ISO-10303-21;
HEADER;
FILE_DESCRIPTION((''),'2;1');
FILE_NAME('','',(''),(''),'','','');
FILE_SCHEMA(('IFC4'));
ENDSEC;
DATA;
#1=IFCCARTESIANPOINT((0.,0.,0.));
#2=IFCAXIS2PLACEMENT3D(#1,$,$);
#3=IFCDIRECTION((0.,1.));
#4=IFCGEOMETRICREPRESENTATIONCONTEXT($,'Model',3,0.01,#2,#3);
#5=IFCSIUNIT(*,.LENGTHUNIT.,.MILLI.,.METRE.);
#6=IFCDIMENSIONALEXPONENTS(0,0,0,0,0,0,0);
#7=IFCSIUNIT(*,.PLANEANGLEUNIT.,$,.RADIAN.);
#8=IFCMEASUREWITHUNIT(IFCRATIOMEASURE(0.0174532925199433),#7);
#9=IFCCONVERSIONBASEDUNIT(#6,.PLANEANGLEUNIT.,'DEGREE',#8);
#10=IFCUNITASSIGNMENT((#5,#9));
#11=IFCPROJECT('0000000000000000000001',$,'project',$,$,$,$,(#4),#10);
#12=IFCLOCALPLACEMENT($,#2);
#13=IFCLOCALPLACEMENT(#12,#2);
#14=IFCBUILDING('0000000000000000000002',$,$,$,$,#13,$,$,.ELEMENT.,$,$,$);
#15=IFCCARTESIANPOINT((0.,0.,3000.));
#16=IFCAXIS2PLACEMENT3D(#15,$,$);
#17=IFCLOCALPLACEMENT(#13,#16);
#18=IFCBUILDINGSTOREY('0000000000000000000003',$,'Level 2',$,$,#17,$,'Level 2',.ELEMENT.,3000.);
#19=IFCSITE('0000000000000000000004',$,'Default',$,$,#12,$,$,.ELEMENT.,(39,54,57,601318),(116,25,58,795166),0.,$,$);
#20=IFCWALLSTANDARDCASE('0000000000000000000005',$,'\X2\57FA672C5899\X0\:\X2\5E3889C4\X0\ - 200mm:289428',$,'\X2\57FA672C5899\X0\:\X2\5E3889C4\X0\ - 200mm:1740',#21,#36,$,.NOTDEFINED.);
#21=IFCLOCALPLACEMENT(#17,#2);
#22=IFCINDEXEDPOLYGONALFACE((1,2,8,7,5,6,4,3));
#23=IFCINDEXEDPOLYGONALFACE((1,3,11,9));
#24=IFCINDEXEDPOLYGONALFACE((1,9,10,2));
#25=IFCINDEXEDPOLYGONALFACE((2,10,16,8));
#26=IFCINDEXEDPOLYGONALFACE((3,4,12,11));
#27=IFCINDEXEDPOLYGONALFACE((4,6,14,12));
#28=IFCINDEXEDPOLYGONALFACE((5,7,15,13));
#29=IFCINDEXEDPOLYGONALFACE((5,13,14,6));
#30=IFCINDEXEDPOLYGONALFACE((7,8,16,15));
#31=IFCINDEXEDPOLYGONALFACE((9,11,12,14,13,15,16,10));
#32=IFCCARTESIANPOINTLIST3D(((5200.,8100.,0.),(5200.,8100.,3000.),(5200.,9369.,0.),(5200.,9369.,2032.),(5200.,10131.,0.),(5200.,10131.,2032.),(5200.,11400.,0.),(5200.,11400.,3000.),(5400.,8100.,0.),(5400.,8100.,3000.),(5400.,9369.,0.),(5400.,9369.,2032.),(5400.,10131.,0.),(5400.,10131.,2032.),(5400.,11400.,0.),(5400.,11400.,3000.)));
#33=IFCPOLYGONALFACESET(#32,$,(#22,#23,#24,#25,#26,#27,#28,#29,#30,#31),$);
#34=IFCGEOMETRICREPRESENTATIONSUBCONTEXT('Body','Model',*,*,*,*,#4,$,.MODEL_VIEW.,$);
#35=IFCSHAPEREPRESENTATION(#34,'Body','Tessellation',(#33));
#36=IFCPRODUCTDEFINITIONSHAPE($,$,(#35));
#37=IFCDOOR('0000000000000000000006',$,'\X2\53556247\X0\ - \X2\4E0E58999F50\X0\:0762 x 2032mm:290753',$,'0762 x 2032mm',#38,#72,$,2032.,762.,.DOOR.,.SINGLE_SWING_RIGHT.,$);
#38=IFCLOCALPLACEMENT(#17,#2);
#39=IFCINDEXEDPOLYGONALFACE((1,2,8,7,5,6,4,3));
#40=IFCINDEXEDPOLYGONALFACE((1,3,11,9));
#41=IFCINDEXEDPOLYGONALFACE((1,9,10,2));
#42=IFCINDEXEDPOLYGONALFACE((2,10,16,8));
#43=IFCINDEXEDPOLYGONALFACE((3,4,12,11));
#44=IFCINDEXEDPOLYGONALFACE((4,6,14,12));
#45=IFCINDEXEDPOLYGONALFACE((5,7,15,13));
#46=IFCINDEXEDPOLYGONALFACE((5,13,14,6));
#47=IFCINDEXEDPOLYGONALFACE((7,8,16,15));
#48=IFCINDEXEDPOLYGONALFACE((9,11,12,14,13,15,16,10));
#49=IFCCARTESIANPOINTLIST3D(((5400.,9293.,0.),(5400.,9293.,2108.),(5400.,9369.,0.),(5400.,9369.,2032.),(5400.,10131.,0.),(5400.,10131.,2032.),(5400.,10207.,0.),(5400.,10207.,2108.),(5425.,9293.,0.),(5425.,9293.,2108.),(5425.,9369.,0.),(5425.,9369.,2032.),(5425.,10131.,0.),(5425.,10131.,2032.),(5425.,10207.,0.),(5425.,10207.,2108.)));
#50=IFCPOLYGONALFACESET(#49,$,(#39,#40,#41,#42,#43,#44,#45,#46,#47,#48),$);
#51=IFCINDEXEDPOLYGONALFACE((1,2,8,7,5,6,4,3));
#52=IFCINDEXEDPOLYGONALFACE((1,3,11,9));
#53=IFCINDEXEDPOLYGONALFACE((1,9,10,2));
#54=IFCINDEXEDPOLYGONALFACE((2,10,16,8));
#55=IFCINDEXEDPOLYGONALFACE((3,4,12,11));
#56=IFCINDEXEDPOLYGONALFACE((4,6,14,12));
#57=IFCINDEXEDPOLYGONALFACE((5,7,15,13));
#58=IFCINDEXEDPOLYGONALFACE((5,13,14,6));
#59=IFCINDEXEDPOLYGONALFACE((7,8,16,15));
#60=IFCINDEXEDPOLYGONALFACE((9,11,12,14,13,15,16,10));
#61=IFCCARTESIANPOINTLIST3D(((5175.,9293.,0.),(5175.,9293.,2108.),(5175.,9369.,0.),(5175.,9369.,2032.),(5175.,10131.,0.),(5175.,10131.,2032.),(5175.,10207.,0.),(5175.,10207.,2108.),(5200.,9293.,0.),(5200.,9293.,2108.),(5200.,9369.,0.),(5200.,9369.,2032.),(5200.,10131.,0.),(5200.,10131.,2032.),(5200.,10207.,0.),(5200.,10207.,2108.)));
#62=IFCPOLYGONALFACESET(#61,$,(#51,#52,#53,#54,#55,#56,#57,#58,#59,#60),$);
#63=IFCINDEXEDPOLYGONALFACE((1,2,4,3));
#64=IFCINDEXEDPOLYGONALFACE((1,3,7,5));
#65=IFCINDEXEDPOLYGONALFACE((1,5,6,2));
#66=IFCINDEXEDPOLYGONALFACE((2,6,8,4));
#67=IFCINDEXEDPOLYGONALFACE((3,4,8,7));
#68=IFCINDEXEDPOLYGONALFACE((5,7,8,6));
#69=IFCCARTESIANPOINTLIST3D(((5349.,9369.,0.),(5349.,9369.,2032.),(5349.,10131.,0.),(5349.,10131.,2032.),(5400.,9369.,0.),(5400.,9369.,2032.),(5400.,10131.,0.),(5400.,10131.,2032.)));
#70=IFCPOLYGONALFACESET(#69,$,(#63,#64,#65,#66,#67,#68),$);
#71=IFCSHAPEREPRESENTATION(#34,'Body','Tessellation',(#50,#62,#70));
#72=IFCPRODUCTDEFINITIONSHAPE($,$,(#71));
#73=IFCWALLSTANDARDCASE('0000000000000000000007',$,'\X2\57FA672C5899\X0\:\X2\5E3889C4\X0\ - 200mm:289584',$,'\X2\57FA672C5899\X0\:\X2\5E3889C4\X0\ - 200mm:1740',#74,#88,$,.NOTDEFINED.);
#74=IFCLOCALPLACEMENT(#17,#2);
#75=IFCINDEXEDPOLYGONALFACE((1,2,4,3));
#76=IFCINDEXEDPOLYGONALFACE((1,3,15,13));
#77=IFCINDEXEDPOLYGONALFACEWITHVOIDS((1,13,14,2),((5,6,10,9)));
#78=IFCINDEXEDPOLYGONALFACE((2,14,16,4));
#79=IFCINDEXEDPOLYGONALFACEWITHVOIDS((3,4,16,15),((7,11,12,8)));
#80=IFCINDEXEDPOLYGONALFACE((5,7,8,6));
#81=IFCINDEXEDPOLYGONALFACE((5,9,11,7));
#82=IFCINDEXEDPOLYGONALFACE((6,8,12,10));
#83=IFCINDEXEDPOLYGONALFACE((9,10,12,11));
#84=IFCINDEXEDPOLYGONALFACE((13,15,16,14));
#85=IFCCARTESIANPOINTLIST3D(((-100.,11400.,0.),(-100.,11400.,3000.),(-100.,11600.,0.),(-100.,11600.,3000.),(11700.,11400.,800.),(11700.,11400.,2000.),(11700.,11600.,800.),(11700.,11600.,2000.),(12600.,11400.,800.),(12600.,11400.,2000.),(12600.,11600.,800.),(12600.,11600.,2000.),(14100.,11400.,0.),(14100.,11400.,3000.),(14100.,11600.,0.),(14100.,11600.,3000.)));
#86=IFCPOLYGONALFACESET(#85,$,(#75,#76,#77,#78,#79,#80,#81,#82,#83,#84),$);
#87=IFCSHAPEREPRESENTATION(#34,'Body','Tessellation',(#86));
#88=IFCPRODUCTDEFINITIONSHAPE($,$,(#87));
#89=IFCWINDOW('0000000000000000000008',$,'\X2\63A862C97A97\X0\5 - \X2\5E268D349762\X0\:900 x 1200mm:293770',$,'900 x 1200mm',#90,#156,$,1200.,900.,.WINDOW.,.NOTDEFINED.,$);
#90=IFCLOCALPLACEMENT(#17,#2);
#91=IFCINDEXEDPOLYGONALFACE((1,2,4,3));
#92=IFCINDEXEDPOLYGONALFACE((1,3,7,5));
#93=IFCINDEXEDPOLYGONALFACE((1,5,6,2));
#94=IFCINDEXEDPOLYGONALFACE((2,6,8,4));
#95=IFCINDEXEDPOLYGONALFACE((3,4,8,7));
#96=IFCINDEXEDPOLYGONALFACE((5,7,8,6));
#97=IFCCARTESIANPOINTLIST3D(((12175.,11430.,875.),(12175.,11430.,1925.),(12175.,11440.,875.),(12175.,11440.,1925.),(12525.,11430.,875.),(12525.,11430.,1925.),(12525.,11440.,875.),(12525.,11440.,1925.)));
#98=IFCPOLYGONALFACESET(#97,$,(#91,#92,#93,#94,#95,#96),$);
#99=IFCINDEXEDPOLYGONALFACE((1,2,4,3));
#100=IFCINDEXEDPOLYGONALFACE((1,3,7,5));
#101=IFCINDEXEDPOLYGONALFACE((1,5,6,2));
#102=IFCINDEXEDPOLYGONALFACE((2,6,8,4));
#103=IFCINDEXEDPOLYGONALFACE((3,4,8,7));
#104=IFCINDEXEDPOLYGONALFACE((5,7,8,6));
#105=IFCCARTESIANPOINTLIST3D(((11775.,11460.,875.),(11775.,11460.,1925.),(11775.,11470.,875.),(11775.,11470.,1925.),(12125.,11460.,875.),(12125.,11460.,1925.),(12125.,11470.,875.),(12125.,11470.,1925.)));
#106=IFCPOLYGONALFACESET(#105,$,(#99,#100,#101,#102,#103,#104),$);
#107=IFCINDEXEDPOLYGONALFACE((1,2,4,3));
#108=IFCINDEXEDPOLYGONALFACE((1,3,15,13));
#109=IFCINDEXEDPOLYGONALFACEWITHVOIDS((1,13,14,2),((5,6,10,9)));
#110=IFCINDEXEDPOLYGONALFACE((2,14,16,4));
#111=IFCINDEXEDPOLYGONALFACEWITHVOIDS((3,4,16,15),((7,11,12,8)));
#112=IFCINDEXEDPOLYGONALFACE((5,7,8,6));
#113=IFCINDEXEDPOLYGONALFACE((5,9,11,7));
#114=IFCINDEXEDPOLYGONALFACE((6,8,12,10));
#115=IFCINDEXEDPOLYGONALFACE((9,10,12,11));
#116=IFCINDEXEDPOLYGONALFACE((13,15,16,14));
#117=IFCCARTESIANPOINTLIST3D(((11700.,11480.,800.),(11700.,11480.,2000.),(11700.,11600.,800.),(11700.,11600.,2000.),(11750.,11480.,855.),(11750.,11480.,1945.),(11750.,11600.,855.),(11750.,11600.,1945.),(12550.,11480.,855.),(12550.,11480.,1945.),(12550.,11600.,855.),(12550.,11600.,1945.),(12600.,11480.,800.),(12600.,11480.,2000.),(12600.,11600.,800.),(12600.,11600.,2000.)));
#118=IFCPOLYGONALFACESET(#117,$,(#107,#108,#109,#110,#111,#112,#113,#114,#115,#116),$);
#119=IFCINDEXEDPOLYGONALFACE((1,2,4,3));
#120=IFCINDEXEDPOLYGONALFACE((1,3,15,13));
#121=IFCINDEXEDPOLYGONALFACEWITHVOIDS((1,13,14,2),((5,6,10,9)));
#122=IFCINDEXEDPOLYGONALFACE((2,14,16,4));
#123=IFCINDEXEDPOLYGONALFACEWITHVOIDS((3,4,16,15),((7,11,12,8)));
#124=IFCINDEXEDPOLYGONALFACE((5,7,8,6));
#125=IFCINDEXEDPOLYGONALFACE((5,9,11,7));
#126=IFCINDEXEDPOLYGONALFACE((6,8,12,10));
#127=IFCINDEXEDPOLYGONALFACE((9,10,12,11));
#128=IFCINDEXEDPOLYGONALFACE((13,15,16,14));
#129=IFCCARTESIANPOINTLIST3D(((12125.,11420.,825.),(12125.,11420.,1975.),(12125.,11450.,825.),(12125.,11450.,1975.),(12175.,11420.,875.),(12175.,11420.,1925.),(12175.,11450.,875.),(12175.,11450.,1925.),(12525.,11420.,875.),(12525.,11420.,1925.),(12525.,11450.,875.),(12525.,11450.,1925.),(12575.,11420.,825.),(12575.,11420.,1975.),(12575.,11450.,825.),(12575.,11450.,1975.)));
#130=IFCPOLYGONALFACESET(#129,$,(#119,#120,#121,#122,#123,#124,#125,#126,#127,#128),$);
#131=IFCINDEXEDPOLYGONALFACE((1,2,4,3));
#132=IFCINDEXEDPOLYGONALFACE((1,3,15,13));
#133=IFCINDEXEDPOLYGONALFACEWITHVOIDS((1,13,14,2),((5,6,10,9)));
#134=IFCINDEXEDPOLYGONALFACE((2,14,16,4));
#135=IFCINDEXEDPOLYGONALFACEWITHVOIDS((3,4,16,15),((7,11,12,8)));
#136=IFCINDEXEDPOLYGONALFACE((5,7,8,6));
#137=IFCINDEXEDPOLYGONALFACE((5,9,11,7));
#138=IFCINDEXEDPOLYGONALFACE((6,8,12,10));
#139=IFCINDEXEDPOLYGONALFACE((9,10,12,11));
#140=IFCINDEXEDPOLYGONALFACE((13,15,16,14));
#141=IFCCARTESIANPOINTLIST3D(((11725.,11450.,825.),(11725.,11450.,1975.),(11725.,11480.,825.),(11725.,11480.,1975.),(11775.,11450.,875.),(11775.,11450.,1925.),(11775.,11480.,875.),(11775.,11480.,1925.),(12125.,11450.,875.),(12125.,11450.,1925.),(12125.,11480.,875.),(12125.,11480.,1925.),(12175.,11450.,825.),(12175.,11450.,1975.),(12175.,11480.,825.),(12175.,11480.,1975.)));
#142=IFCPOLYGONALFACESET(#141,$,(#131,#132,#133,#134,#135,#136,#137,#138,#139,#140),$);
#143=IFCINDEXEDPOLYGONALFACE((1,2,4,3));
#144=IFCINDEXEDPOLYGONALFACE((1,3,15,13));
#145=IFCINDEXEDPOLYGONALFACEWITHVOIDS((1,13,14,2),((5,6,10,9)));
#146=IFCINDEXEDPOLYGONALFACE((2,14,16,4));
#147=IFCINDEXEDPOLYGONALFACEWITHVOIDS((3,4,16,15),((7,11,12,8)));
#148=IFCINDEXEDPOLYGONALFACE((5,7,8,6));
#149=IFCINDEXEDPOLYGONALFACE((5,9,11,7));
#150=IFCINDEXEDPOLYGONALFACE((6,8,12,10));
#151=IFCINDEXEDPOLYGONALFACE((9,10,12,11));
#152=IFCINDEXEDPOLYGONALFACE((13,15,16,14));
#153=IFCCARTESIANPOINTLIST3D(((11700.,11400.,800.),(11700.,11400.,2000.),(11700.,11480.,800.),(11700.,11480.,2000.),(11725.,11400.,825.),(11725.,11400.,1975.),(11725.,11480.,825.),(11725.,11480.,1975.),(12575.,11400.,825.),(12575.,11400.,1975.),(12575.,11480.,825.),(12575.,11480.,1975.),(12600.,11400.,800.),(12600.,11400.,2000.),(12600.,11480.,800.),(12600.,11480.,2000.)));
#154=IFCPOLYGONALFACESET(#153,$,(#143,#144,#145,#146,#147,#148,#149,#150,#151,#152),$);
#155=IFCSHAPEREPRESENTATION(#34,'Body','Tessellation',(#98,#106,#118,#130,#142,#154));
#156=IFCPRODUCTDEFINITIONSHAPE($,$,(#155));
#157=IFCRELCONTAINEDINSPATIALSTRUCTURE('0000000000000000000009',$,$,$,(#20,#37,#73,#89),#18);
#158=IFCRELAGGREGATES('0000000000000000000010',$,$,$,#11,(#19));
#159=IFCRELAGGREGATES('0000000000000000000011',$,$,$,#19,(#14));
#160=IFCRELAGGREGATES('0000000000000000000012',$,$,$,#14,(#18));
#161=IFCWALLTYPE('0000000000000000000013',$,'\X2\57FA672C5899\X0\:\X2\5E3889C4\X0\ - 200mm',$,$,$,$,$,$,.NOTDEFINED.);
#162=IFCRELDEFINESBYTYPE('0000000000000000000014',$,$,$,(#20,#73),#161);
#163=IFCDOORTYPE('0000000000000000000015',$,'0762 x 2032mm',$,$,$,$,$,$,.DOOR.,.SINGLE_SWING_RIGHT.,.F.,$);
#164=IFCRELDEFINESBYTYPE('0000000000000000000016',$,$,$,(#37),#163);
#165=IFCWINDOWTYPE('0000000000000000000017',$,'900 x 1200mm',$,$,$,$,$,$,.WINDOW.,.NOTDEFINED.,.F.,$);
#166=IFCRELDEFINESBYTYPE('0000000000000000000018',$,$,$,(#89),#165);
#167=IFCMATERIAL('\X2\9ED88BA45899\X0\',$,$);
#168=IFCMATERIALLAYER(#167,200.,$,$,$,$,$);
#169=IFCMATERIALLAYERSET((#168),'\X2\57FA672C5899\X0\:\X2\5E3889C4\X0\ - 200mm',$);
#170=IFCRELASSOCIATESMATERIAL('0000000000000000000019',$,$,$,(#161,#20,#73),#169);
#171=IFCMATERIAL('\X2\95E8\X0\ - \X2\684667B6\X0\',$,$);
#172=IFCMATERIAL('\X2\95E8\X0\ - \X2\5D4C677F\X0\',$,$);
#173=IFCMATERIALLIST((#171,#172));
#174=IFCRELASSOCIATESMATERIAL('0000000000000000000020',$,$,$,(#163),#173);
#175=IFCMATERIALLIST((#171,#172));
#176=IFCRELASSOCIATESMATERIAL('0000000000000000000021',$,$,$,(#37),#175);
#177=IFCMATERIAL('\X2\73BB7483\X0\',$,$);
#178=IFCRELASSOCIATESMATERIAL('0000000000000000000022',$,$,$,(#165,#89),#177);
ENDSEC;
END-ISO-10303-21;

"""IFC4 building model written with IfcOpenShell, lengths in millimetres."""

from ifc_helpers import new_model, entity, si_unit, converted_unit, direction, frame, frame_2d, origin, origin_2d_with_axis, place, context, subcontext, project, spatial, polyline, rectangle, outline, extrude, source, transform, mapped, material, material_list, layer, layer_set, layer_usage, type_object, type_shapes, element, fill, save


model = new_model("IFC4")

# Units and contexts
model_context = context("Model", 3, precision=0.01, world=origin(), true_north=direction((0.0, 1.0)))
body_context = subcontext(model_context, "Body", "Model", "MODEL_VIEW")
ifc_project = project(units=[si_unit("LENGTHUNIT", "METRE", prefix="MILLI"), converted_unit("PLANEANGLEUNIT", "DEGREE", entity("IfcRatioMeasure", 0.0174532925199433), si_unit("PLANEANGLEUNIT", "RADIAN"), dimensions=[0, 0, 0, 0, 0, 0, 0])], contexts=[model_context])

# Site, building, storey
site_placement = place(None, origin())
site = spatial("IfcSite", under=ifc_project, at=site_placement, Name="Default", CompositionType="ELEMENT", RefLatitude=(39, 54, 57, 601318), RefLongitude=(116, 25, 58, 795166), RefElevation=0.0)
building_placement = place(site_placement, origin())
building = spatial("IfcBuilding", under=site, at=building_placement, CompositionType="ELEMENT")
storey_placement = place(building_placement, frame((0.0, 0.0, 3000.0)))
storey = spatial("IfcBuildingStorey", under=building, at=storey_placement, Name="Level 2", LongName="Level 2", CompositionType="ELEMENT", Elevation=3000.0)

# Shared definitions
ifc_material_1 = material(Name="默认墙")
ifc_layer_1 = layer(ifc_material_1, 200.0)
ifc_layer_set_1 = layer_set([ifc_layer_1], Name="基本墙:常规 - 200mm")
wall_type = type_object("IfcWallType", Name="基本墙:常规 - 200mm", PredefinedType="NOTDEFINED", material=ifc_layer_set_1)

# Wall, opening, door
ifc_layer_usage_1 = layer_usage(ifc_layer_set_1, "AXIS2", "NEGATIVE", 100.0)
wall_1_placement = place(storey_placement, frame((5300.0, 8100.0, 0.0), z_axis=(0.0, 0.0, 1.0), x_axis=(0.0, 1.0, 0.0)))
wall_1 = element("IfcWallStandardCase", 1, at=wall_1_placement, inside=storey, type_object=wall_type, material=ifc_layer_usage_1, Name="基本墙:常规 - 200mm:289428", ObjectType="基本墙:常规 - 200mm:1740", PredefinedType="NOTDEFINED", context=body_context, shape_type="SweptSolid", body=[
    extrude(rectangle(XDim=3300.0, YDim=200.0, at=frame_2d((1650.0, 0.0), x_axis=(-1.0, 0.0))), origin(), (0.0, 0.0, 1.0), 3000.0),
])
opening_1_placement = place(wall_1_placement, frame((2031.0, 100.0, 0.0)))
opening_1 = element("IfcOpeningElement", 2, at=opening_1_placement, cuts=wall_1, ObjectType="Opening", PredefinedType="OPENING", context=body_context, shape_type="SweptSolid", body=[
    extrude(rectangle(XDim=762.0, YDim=2032.0, at=frame_2d((1016.0, 381.0), x_axis=(0.0, 1.0))), frame((0.0, 0.0, 0.0), z_axis=(0.0, -1.0, 0.0), x_axis=(0.0, 0.0, 1.0)), (0.0, 0.0, 1.0), 200.0),
])
ifc_material_2 = material(Name="门 - 框架")
ifc_material_3 = material(Name="门 - 嵌板")
ifc_material_list_1 = material_list([ifc_material_2, ifc_material_3])
ifc_material_list_2 = material_list([ifc_material_2, ifc_material_3])
door_type = type_object("IfcDoorType", Name="0762 x 2032mm", OperationType="SINGLE_SWING_RIGHT", ParameterTakesPrecedence=False, PredefinedType="DOOR", material=ifc_material_list_2)
shared_shape_1 = source(origin(), body_context, "Body", "SweptSolid", [
    extrude(outline(polyline([(-457.0, -1073.0), (457.0, -1073.0), (457.0, 1035.0), (381.0, 1035.0), (381.0, -997.0), (-381.0, -997.0), (-381.0, 1035.0), (-457.0, 1035.0), (-457.0, -1073.0)])), frame((381.0, 200.0, 1035.0), z_axis=(0.0, 1.0, 0.0), x_axis=(1.0, 0.0, 0.0)), (0.0, 0.0, 1.0), 25.0),
    extrude(outline(polyline([(-1073.0, -457.0), (1035.0, -457.0), (1035.0, -381.0), (-997.0, -381.0), (-997.0, 381.0), (1035.0, 381.0), (1035.0, 457.0), (-1073.0, 457.0), (-1073.0, -457.0)])), frame((381.0, -25.0, 1035.0), z_axis=(0.0, 1.0, 0.0), x_axis=(0.0, 0.0, -1.0)), (0.0, 0.0, 1.0), 25.0),
    extrude(rectangle(XDim=51.0, YDim=762.0, at=frame_2d((0.0, 0.0), x_axis=(1.0, 0.0))), frame((381.0, 174.5, 0.0), z_axis=(0.0, 0.0, 1.0), x_axis=(0.0, 1.0, 0.0)), (0.0, 0.0, 1.0), 2032.0),
])
type_shapes(door_type, [shared_shape_1])
door_placement = place(opening_1_placement, frame((0.0, 0.0, 0.0), z_axis=(0.0, 0.0, 1.0), x_axis=(-1.0, 0.0, 0.0)))
door = element("IfcDoor", 3, at=door_placement, inside=storey, type_object=door_type, material=ifc_material_list_1, Name="单扇 - 与墙齐:0762 x 2032mm:290753", ObjectType="0762 x 2032mm", OperationType="SINGLE_SWING_RIGHT", OverallHeight=2032.0, OverallWidth=762.0, PredefinedType="DOOR", context=body_context, shape_type="MappedRepresentation", body=[
    mapped(shared_shape_1, transform((0.0, 0.0, 0.0), scale=1.0)),
])
fill(opening_1, door)

# Wall, opening, window
ifc_layer_usage_2 = layer_usage(ifc_layer_set_1, "AXIS2", "NEGATIVE", 100.0)
wall_2_placement = place(storey_placement, frame((-100.0, 11500.0, 0.0)))
wall_2 = element("IfcWallStandardCase", 4, at=wall_2_placement, inside=storey, type_object=wall_type, material=ifc_layer_usage_2, Name="基本墙:常规 - 200mm:289584", ObjectType="基本墙:常规 - 200mm:1740", PredefinedType="NOTDEFINED", context=body_context, shape_type="SweptSolid", body=[
    extrude(rectangle(XDim=14200.0, YDim=200.0, at=frame_2d((7100.0, 0.0), x_axis=(-1.0, 0.0))), origin(), (0.0, 0.0, 1.0), 3000.0),
])
opening_2_placement = place(wall_2_placement, frame((12700.0, 100.0, 800.0)))
opening_2 = element("IfcOpeningElement", 5, at=opening_2_placement, cuts=wall_2, ObjectType="Opening", PredefinedType="OPENING", context=body_context, shape_type="SweptSolid", body=[
    extrude(rectangle(XDim=1200.0, YDim=900.0, at=frame_2d((600.0, 450.0), x_axis=(-1.0, 0.0))), frame((0.0, 0.0, 0.0), z_axis=(0.0, -1.0, 0.0), x_axis=(0.0, 0.0, 1.0)), (0.0, 0.0, 1.0), 200.0),
])
ifc_material_4 = material(Name="玻璃")
window_type = type_object("IfcWindowType", Name="900 x 1200mm", ParameterTakesPrecedence=False, PartitioningType="NOTDEFINED", PredefinedType="WINDOW", material=ifc_material_4)
shared_shape_2 = source(origin(), body_context, "Body", "SweptSolid", [
    extrude(rectangle(XDim=10.0, YDim=350.0, at=origin_2d_with_axis()), frame((250.0, 165.0, 75.0), z_axis=(0.0, 0.0, 1.0), x_axis=(0.0, -1.0, 0.0)), (0.0, 0.0, 1.0), 1050.0),
    extrude(rectangle(XDim=10.0, YDim=350.0, at=frame_2d((0.0, 0.0), x_axis=(1.0, 0.0))), frame((650.0, 135.0, 75.0), z_axis=(0.0, 0.0, 1.0), x_axis=(0.0, -1.0, 0.0)), (0.0, 0.0, 1.0), 1050.0),
    extrude(outline(polyline([(-450.0, -600.0), (450.0, -600.0), (450.0, 600.0), (-450.0, 600.0), (-450.0, -600.0)]), holes=[polyline([(400.0, -545.0), (-400.0, -545.0), (-400.0, 545.0), (400.0, 545.0), (400.0, -545.0)])]), frame((450.0, 0.0, 600.0), z_axis=(0.0, 1.0, 0.0), x_axis=(1.0, 0.0, 0.0)), (0.0, 0.0, 1.0), 120.0),
    extrude(outline(polyline([(-225.0, -575.0), (225.0, -575.0), (225.0, 575.0), (-225.0, 575.0), (-225.0, -575.0)]), holes=[polyline([(-175.0, -525.0), (-175.0, 525.0), (175.0, 525.0), (175.0, -525.0), (-175.0, -525.0)])]), frame((250.0, 150.0, 600.0), z_axis=(0.0, 1.0, 0.0), x_axis=(-1.0, 0.0, 0.0)), (0.0, 0.0, 1.0), 30.0),
    extrude(outline(polyline([(-225.0, -575.0), (225.0, -575.0), (225.0, 575.0), (-225.0, 575.0), (-225.0, -575.0)]), holes=[polyline([(-175.0, -525.0), (-175.0, 525.0), (175.0, 525.0), (175.0, -525.0), (-175.0, -525.0)])]), frame((650.0, 120.0, 600.0), z_axis=(0.0, 1.0, 0.0), x_axis=(1.0, 0.0, 0.0)), (0.0, 0.0, 1.0), 30.0),
    extrude(outline(polyline([(-450.0, -600.0), (450.0, -600.0), (450.0, 600.0), (-450.0, 600.0), (-450.0, -600.0)]), holes=[polyline([(-425.0, 575.0), (425.0, 575.0), (425.0, -575.0), (-425.0, -575.0), (-425.0, 575.0)])]), frame((450.0, 120.0, 600.0), z_axis=(0.0, 1.0, 0.0), x_axis=(1.0, 0.0, 0.0)), (0.0, 0.0, 1.0), 80.0),
])
type_shapes(window_type, [shared_shape_2])
window_1_placement = place(opening_2_placement, frame((0.0, 0.0, 0.0), z_axis=(0.0, 0.0, 1.0), x_axis=(-1.0, 0.0, 0.0)))
window_1 = element("IfcWindow", 6, at=window_1_placement, inside=storey, type_object=window_type, material=ifc_material_4, Name="推拉窗5 - 带贴面:900 x 1200mm:293770", ObjectType="900 x 1200mm", OverallHeight=1200.0, OverallWidth=900.0, PartitioningType="NOTDEFINED", PredefinedType="WINDOW", context=body_context, shape_type="MappedRepresentation", body=[
    mapped(shared_shape_2, transform((0.0, 0.0, 0.0), scale=1.0)),
])
fill(opening_2, window_1)

save(model, "model.ifc")
